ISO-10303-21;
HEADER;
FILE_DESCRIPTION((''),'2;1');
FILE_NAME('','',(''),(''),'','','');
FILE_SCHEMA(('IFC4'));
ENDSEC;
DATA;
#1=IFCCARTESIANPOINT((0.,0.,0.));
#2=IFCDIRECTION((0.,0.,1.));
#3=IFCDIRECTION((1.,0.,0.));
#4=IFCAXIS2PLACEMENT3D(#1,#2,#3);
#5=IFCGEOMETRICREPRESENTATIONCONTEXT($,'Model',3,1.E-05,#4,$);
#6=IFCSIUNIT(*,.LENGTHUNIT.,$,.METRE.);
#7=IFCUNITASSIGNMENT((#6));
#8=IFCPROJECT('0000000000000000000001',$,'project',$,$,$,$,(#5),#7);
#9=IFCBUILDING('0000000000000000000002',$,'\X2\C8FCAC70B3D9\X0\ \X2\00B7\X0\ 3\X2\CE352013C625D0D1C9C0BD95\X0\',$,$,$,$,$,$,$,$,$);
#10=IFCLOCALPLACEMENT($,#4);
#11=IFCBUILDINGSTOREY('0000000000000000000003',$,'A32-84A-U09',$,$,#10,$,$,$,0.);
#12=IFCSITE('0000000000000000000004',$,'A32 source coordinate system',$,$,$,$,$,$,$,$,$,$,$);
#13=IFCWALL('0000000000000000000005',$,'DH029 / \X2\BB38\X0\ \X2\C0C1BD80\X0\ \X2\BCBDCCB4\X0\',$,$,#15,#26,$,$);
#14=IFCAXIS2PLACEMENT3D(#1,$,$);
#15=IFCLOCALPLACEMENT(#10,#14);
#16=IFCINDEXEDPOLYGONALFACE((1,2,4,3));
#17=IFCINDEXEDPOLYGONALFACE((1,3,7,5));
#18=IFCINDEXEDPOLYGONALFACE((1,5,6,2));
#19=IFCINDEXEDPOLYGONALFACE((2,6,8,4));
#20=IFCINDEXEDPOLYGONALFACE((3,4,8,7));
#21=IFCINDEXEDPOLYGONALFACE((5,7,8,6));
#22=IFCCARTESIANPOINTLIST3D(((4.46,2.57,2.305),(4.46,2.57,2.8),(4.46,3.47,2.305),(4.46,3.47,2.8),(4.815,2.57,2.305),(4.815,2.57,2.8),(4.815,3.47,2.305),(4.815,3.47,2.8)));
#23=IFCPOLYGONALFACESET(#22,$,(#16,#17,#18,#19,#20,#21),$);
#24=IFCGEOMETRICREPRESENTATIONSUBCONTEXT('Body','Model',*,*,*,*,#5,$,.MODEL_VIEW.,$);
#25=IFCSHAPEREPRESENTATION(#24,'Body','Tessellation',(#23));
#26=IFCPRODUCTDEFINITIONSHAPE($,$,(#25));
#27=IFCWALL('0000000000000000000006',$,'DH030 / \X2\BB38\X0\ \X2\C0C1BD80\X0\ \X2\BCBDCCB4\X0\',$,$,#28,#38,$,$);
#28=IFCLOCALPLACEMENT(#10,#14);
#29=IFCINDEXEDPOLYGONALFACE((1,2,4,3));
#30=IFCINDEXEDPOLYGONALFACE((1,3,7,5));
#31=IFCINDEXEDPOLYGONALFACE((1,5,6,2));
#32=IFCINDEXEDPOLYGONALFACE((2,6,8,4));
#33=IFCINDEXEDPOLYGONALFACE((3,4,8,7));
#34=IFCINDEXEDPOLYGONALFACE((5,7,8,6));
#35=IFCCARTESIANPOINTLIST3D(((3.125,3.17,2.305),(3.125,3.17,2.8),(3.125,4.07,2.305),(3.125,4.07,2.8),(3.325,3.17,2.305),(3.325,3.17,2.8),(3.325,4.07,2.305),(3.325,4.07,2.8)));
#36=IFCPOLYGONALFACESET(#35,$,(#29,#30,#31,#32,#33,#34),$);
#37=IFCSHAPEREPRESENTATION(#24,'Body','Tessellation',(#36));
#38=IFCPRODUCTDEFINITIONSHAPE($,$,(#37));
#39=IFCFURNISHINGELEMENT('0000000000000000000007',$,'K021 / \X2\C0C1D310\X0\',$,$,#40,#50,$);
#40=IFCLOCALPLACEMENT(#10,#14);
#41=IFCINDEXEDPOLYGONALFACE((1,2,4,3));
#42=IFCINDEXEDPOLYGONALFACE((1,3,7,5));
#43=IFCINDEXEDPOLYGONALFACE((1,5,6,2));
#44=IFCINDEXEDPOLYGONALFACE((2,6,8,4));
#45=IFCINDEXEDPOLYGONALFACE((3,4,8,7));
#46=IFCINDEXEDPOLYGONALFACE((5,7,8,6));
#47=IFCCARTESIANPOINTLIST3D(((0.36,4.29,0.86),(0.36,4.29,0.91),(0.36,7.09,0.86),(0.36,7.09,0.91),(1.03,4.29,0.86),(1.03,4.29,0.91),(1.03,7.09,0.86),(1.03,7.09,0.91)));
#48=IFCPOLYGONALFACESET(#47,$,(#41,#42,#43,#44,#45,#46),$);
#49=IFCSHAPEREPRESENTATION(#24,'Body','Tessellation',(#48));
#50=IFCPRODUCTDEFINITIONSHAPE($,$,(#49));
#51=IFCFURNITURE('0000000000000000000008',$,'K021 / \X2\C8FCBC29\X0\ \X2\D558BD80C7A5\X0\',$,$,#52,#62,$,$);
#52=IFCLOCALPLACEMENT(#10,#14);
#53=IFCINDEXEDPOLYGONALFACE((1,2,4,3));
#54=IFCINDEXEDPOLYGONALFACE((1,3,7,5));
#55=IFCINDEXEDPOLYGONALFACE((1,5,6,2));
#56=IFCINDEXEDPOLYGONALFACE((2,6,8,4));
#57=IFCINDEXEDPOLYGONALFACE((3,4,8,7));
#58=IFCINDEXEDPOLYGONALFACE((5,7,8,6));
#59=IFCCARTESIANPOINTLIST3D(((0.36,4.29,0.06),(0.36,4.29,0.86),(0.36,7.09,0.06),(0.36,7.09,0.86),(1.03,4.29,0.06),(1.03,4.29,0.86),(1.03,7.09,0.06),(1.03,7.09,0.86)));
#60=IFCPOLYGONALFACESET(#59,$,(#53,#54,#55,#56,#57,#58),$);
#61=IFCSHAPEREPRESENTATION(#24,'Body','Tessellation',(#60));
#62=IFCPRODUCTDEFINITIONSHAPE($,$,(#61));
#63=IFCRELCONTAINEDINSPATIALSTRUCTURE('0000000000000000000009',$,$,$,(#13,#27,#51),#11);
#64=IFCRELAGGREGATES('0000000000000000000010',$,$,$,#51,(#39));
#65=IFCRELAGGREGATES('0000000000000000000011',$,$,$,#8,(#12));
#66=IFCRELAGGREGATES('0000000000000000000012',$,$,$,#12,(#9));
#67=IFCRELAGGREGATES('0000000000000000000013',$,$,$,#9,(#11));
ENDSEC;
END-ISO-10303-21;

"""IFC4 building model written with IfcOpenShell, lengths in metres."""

from ifc_helpers import new_model, si_unit, frame, origin_with_axes, place, context, subcontext, project, spatial, polyline, outline, extrude, element, aggregate, save


model = new_model("IFC4")

# Units and contexts
model_context = context("Model", 3, precision=1e-05, world=origin_with_axes())
body_context = subcontext(model_context, "Body", "Model", "MODEL_VIEW")
ifc_project = project(units=[si_unit("LENGTHUNIT", "METRE")], contexts=[model_context])

# Site, building, storey
site = spatial("IfcSite", under=ifc_project, Name="A32 source coordinate system")
building = spatial("IfcBuilding", under=site, Name="주거동 · 3층–옥탑지붕")
storey_placement = place(None, origin_with_axes())
storey = spatial("IfcBuildingStorey", under=building, at=storey_placement, Name="A32-84A-U09", Elevation=0.0)

# Walls
wall_1_placement = place(storey_placement, origin_with_axes())
element("IfcWall", 1, at=wall_1_placement, inside=storey, Name="DH029 / 문 상부 벽체", context=body_context, shape_type="SweptSolid", body=[
    extrude(outline(polyline([(4.815, 3.47), (4.815, 2.57), (4.46, 2.57), (4.46, 3.47), (4.815, 3.47)])), frame((0.0, 0.0, 2.305)), (0.0, 0.0, 1.0), 0.495),
])
wall_2_placement = place(storey_placement, origin_with_axes())
element("IfcWall", 2, at=wall_2_placement, inside=storey, Name="DH030 / 문 상부 벽체", context=body_context, shape_type="SweptSolid", body=[
    extrude(outline(polyline([(3.325, 4.07), (3.325, 3.17), (3.125, 3.17), (3.125, 4.07), (3.325, 4.07)])), frame((0.0, 0.0, 2.305)), (0.0, 0.0, 1.0), 0.495),
])

# Furnishing element
furniture_placement = place(storey_placement, origin_with_axes())
furnishing_placement = place(furniture_placement, origin_with_axes())
furnishing = element("IfcFurnishingElement", 3, at=furnishing_placement, Name="K021 / 상판", context=body_context, shape_type="SweptSolid", body=[
    extrude(outline(polyline([(0.36, 7.09), (1.03, 7.09), (1.03, 4.29), (0.36, 4.29), (0.36, 7.09)])), frame((0.0, 0.0, 0.86)), (0.0, 0.0, 1.0), 0.05),
])

# Furniture
furniture = element("IfcFurniture", 4, at=furniture_placement, inside=storey, Name="K021 / 주방 하부장", context=body_context, shape_type="SweptSolid", body=[
    extrude(outline(polyline([(0.36, 4.29), (0.36, 7.09), (1.03, 7.09), (1.03, 4.29), (0.36, 4.29)])), frame((0.0, 0.0, 0.06)), (0.0, 0.0, 1.0), 0.8),
])
aggregate(furniture, [furnishing])

save(model, "model.ifc")
